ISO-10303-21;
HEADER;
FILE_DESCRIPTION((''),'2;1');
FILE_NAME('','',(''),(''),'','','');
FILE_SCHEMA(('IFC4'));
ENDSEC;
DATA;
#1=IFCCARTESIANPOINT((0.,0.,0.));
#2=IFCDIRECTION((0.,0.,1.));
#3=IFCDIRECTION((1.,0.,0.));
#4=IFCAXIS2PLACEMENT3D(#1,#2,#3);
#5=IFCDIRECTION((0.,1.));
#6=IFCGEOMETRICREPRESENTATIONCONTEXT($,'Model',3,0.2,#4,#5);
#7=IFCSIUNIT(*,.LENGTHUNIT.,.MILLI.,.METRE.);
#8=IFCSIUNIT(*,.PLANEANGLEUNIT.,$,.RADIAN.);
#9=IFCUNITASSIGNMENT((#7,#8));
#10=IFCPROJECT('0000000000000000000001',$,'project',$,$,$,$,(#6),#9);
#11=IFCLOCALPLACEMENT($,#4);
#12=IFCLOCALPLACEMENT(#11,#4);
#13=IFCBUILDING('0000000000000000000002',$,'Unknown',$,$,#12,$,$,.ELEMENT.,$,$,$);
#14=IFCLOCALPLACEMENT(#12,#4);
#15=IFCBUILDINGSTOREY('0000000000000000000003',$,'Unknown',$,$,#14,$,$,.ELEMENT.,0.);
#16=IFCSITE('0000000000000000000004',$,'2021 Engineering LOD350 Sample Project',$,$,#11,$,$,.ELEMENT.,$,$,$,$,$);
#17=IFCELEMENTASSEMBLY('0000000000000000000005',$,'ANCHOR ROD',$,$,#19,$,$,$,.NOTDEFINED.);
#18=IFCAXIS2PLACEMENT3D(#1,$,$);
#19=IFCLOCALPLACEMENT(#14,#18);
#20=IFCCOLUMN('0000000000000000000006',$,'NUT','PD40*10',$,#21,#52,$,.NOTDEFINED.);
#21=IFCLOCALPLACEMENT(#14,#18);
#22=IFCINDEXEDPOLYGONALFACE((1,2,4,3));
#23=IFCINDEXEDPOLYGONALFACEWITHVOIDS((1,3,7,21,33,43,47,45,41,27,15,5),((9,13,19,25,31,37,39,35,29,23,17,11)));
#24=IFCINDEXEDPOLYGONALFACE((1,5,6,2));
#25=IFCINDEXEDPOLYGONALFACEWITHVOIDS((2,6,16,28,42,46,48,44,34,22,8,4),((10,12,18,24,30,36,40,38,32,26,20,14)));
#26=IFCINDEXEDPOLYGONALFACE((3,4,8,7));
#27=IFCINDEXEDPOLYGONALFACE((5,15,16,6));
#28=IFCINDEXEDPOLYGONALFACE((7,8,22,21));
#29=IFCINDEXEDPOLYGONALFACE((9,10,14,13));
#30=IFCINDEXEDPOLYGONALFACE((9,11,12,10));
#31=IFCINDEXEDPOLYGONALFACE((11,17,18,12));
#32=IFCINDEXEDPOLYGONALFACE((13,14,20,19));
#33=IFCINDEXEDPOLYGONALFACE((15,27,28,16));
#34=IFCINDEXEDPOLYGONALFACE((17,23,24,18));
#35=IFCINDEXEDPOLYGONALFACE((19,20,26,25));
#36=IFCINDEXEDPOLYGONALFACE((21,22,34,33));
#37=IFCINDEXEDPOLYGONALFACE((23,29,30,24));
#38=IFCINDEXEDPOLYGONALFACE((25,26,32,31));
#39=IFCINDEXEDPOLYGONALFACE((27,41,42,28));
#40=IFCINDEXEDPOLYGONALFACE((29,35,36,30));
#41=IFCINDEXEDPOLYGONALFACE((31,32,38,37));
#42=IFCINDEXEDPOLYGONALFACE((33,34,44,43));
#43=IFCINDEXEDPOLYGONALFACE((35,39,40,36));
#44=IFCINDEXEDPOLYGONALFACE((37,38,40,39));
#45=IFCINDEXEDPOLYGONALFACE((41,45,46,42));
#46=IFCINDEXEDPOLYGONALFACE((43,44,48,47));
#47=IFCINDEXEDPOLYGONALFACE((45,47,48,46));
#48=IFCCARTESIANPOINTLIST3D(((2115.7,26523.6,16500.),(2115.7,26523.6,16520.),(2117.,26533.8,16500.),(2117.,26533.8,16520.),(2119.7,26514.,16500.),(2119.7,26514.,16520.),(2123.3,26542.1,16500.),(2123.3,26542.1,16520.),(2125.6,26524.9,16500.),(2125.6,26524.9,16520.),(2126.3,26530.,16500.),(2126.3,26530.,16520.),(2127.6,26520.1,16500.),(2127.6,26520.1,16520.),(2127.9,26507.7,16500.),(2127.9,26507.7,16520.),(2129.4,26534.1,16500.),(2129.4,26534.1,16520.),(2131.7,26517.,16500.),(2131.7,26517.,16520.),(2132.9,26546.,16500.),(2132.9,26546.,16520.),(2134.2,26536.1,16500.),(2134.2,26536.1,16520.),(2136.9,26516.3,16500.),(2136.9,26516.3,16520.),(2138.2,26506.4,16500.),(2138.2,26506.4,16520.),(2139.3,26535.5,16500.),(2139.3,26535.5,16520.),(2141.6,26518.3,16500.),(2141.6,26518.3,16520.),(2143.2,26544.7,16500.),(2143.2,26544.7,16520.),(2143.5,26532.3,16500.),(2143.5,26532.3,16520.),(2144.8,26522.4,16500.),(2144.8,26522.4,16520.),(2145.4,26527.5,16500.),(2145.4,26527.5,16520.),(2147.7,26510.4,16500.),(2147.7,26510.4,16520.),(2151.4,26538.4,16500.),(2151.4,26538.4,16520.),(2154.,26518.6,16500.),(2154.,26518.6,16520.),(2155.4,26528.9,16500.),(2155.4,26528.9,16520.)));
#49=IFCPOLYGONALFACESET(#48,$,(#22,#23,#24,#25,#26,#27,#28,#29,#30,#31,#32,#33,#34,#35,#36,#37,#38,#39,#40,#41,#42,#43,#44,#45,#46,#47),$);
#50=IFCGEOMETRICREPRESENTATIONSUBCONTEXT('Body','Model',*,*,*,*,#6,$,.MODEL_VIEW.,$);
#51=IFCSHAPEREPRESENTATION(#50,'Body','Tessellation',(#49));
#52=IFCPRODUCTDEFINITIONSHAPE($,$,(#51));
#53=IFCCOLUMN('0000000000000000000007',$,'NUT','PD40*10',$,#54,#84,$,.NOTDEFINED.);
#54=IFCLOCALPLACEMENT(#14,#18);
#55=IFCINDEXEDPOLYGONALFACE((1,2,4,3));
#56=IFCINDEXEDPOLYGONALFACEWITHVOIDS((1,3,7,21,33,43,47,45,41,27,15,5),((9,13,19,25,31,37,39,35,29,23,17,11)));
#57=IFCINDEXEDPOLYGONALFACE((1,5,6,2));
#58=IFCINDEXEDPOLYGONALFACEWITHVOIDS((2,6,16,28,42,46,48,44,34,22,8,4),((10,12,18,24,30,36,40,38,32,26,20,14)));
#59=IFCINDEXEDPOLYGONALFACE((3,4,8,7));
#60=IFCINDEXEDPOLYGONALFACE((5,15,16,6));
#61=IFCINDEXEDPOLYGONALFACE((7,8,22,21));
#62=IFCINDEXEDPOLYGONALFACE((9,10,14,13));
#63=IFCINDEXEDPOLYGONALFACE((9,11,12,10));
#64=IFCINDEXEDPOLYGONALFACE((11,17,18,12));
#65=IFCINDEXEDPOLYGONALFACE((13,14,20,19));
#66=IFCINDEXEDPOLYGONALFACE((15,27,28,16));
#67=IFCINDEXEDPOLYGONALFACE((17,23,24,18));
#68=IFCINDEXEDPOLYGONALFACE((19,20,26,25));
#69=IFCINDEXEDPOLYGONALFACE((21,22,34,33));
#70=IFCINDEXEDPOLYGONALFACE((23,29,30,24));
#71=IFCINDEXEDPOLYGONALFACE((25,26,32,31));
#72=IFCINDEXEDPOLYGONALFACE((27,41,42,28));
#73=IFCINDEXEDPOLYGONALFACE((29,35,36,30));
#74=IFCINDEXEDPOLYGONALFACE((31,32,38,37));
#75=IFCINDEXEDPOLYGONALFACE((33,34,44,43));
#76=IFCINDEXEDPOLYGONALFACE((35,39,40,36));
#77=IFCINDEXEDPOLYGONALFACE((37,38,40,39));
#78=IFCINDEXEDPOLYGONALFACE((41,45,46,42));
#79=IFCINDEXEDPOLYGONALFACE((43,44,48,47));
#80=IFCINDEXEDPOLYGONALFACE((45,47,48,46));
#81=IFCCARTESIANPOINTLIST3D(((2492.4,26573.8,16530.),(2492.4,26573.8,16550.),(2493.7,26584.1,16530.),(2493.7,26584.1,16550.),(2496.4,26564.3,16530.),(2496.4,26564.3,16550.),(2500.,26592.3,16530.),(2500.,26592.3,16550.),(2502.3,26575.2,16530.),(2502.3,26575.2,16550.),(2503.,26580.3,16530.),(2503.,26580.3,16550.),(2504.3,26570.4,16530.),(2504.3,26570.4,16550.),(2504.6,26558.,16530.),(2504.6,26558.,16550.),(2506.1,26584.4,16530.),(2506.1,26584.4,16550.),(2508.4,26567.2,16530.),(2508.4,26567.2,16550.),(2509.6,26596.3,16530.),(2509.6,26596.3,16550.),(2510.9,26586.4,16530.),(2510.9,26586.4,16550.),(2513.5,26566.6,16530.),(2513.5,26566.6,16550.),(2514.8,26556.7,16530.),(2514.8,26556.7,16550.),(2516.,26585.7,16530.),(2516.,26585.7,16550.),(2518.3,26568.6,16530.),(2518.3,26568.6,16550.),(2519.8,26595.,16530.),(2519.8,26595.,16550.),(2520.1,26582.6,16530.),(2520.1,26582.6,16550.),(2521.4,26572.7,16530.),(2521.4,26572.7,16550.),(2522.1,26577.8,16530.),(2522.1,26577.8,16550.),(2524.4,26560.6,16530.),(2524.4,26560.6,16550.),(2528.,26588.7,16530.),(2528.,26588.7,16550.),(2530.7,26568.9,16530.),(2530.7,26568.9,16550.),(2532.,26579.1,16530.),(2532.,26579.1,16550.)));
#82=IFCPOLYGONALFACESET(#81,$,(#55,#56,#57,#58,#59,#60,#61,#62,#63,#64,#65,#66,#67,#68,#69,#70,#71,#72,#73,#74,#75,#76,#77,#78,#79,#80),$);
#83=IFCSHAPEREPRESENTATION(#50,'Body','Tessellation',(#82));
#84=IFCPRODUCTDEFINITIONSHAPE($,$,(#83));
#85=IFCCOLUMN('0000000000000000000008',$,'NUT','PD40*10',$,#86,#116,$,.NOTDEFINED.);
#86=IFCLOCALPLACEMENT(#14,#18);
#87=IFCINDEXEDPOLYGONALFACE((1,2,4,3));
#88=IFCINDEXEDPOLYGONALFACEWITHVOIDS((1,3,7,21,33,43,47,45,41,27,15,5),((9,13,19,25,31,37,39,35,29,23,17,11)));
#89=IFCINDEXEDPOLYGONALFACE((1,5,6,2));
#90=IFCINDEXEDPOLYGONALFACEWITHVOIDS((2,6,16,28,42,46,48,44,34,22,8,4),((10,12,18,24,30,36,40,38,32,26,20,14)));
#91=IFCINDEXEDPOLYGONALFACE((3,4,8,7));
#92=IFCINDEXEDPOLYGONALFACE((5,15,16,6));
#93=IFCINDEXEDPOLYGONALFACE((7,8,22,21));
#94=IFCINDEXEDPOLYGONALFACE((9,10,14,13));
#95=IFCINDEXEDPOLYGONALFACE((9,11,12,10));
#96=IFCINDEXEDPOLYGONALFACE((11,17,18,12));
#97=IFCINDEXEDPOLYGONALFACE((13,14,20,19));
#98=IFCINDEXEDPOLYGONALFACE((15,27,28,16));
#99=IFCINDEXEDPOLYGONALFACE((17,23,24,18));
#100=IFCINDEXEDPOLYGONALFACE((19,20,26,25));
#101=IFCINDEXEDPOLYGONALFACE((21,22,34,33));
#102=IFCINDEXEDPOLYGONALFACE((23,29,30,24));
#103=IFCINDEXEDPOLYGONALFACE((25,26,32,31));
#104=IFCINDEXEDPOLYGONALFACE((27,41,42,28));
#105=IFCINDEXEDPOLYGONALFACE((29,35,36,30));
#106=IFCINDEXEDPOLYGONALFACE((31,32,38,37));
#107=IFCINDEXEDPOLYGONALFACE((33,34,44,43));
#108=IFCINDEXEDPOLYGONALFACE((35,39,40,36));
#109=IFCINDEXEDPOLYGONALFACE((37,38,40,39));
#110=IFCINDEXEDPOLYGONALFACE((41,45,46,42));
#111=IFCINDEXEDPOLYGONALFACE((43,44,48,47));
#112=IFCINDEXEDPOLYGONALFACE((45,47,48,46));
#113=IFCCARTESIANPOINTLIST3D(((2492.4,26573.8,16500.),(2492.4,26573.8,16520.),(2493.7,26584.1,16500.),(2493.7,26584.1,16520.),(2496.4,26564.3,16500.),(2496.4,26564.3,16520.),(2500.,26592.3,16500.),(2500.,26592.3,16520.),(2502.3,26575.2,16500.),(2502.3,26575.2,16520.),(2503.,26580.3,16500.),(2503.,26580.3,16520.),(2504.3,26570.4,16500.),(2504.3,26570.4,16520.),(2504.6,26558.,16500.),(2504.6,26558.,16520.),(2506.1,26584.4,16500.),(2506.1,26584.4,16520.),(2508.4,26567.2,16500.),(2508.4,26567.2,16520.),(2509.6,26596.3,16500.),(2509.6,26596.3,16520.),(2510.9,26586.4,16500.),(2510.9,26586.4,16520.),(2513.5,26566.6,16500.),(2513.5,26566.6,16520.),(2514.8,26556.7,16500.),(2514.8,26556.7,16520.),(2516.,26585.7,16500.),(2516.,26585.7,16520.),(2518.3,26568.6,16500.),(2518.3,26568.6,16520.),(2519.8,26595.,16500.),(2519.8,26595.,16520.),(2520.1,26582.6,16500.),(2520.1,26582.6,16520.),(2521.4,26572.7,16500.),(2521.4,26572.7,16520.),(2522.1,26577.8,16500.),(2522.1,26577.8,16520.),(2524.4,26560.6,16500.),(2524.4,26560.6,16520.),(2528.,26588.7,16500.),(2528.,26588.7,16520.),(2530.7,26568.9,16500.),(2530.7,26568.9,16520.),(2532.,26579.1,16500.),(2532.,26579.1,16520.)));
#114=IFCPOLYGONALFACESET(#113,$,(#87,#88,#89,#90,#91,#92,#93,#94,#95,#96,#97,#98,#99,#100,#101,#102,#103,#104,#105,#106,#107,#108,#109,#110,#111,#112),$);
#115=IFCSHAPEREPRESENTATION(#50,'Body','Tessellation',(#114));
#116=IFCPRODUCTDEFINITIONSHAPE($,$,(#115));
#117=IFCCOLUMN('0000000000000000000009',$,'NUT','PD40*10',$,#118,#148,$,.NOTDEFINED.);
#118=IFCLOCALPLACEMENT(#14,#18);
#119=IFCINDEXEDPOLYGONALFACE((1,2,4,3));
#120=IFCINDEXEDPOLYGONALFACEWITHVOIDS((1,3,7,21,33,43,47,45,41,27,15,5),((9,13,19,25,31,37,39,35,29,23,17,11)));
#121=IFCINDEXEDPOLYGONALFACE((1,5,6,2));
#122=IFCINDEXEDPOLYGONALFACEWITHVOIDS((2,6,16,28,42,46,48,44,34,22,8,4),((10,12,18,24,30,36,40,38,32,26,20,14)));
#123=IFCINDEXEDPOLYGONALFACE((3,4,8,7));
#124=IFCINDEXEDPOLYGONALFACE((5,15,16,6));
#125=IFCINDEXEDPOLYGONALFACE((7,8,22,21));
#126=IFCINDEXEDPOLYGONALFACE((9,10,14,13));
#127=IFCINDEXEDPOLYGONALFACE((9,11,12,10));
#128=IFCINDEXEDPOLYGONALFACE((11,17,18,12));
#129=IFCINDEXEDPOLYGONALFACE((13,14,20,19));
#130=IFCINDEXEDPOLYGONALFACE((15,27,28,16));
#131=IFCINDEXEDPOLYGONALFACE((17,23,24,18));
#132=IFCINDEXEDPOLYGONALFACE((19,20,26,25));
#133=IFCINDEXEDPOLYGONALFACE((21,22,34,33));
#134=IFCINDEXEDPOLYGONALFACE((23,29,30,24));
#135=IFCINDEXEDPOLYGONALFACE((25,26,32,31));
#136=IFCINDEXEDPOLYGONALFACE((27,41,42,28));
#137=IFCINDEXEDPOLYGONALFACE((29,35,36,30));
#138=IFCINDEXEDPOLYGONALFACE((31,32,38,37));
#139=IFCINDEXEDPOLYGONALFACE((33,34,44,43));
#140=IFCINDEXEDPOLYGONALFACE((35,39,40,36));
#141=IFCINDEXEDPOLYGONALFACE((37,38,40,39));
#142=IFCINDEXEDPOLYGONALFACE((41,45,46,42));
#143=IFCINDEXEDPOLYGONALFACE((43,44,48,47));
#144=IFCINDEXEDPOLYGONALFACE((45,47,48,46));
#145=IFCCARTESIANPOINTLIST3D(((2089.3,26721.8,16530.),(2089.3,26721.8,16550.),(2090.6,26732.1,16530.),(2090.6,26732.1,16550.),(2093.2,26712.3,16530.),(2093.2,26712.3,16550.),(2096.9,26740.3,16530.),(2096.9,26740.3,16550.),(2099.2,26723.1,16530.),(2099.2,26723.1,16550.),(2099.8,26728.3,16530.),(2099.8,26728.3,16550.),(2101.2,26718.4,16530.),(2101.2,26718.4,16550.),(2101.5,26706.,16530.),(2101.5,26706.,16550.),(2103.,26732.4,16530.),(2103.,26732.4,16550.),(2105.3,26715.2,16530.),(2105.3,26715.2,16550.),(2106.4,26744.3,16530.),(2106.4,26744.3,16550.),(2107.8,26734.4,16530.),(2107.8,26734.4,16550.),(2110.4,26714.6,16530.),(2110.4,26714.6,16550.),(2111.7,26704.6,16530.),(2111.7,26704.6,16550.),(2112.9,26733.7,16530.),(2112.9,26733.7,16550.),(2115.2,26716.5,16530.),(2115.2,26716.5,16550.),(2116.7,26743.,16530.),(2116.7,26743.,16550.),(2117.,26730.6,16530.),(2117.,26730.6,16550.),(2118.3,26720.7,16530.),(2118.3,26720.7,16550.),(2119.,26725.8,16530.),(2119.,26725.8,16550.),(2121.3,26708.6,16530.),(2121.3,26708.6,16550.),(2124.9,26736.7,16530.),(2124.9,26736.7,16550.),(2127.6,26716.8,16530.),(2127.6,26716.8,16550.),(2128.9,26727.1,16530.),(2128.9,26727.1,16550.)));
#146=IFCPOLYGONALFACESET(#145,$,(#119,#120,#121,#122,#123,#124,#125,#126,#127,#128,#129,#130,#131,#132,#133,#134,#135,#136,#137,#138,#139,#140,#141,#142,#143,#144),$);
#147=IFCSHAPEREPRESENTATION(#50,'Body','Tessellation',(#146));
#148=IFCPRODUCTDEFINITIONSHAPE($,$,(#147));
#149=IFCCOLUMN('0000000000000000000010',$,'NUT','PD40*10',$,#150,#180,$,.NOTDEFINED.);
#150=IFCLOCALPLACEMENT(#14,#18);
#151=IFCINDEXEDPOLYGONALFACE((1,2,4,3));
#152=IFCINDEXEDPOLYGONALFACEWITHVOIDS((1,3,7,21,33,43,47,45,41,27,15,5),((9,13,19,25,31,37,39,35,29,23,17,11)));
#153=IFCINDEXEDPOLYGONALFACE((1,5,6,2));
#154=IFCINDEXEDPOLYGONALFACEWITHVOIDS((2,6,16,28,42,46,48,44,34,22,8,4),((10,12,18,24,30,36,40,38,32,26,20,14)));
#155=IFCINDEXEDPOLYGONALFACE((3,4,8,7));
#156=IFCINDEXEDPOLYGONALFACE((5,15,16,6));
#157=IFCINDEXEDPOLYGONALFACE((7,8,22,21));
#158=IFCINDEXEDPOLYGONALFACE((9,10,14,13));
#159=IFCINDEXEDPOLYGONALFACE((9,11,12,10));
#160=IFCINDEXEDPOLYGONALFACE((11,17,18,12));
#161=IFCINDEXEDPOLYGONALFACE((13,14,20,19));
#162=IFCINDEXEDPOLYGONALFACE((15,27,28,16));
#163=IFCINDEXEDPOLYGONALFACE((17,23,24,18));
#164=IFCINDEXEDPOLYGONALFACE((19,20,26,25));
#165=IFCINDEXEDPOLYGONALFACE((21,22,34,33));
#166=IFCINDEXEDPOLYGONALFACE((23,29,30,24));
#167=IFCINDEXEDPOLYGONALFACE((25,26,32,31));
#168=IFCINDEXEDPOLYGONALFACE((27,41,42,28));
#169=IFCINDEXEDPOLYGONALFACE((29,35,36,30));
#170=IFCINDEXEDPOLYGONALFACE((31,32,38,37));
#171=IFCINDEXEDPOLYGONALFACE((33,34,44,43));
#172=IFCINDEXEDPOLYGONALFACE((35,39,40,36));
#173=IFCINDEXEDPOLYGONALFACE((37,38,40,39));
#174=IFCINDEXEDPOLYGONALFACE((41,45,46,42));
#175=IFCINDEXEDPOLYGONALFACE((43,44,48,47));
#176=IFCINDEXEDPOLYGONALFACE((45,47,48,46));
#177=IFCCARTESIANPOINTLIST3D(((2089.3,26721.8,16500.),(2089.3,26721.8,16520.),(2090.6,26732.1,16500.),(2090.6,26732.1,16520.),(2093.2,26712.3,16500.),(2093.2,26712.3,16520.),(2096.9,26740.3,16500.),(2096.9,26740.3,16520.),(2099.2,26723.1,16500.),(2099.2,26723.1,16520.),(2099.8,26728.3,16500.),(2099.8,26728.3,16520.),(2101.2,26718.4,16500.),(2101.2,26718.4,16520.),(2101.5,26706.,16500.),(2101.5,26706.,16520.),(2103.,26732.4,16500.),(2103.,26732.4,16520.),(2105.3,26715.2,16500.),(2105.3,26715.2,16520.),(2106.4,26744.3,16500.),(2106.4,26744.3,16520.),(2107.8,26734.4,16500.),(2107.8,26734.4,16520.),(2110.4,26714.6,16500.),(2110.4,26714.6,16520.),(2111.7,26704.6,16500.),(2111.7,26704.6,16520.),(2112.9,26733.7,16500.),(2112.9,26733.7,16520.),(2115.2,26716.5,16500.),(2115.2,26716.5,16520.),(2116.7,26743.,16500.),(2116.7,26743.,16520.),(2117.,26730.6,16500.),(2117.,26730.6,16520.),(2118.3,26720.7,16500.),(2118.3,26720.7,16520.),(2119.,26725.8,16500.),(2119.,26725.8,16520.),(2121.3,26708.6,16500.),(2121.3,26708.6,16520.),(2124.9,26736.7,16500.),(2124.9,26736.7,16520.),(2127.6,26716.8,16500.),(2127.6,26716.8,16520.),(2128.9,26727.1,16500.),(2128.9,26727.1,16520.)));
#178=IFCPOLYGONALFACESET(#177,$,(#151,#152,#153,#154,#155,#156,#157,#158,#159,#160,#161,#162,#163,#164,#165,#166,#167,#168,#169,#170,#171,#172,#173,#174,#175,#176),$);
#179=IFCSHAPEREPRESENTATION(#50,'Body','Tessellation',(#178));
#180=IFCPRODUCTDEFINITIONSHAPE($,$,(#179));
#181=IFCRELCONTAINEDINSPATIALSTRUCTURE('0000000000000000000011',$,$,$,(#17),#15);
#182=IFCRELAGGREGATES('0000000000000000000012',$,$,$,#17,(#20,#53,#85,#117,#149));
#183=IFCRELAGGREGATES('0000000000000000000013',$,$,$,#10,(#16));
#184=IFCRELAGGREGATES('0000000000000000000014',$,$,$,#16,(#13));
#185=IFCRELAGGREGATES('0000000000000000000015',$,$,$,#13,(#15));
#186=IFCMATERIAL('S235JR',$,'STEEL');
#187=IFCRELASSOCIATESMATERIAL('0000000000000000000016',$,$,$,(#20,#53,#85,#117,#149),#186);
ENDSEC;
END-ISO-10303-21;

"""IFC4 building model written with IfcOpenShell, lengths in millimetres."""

from ifc_helpers import new_model, si_unit, direction, frame, origin_with_axes, place, context, subcontext, project, spatial, line, indexed_curve, outline, extrude, material, element, aggregate, save


model = new_model("IFC4")

# Units and contexts
model_context = context("Model", 3, precision=0.2, world=origin_with_axes(), true_north=direction((0.0, 1.0)))
body_context = subcontext(model_context, "Body", "Model", "MODEL_VIEW")
ifc_project = project(units=[si_unit("LENGTHUNIT", "METRE", prefix="MILLI"), si_unit("PLANEANGLEUNIT", "RADIAN")], contexts=[model_context])

# Site, building, storey
site_placement = place(None, origin_with_axes())
site = spatial("IfcSite", under=ifc_project, at=site_placement, Name="2021 Engineering LOD350 Sample Project", CompositionType="ELEMENT")
building_placement = place(site_placement, origin_with_axes())
building = spatial("IfcBuilding", under=site, at=building_placement, Name="Unknown", CompositionType="ELEMENT")
storey_placement = place(building_placement, origin_with_axes())
storey = spatial("IfcBuildingStorey", under=building, at=storey_placement, Name="Unknown", CompositionType="ELEMENT", Elevation=0.0)

# Element assembly, columns
assembly_1_placement = place(storey_placement, frame((2485.7, 26774.7, 16730.0), z_axis=(0.991216, 0.132256, 0.0), x_axis=(0.0, 0.0, -1.0)))
assembly_1 = element("IfcElementAssembly", 1, at=assembly_1_placement, inside=storey, Name="ANCHOR ROD", PredefinedType="NOTDEFINED")
ifc_material_1 = material(Name="S235JR", Category="STEEL")
column_1_placement = place(assembly_1_placement, frame((210.0, -200.0, -380.0), z_axis=(0.0, 0.0, -1.0), x_axis=(1.0, 0.0, 0.0)))
column_1 = element("IfcColumn", 2, at=column_1_placement, material=ifc_material_1, Name="NUT", Description="PD40*10", PredefinedType="NOTDEFINED", context=body_context, shape_type="SolidModel", body=[
    extrude(outline(indexed_curve([(20.0, 0.0), (17.3, 10.0), (10.0, 17.3), (0.0, 20.0), (-10.0, 17.3), (-17.3, 10.0), (-20.0, 0.0), (-17.3, -10.0), (-10.0, -17.3), (0.0, -20.0), (10.0, -17.3), (17.3, -10.0)], segments=[line(1, 2, 3, 4, 5, 6, 7, 8, 9, 10, 11, 12, 1)]), holes=[indexed_curve([(10.0, 0.0), (8.7, -5.0), (5.0, -8.7), (0.0, -10.0), (-5.0, -8.7), (-8.7, -5.0), (-10.0, 0.0), (-8.7, 5.0), (-5.0, 8.7), (0.0, 10.0), (5.0, 8.7), (8.7, 5.0)], segments=[line(1, 2, 3, 4, 5, 6, 7, 8, 9, 10, 11, 12, 1)])]), frame((0.0, 0.0, 0.0), z_axis=(-1.0, 0.0, 0.0), x_axis=(0.0, 0.0, 1.0)), (0.0, 0.0, -1.0), 20.0),
])
column_2_placement = place(assembly_1_placement, frame((180.0, -200.0, 0.0), z_axis=(0.0, 0.0, 1.0), x_axis=(1.0, 0.0, 0.0)))
column_2 = element("IfcColumn", 3, at=column_2_placement, material=ifc_material_1, Name="NUT", Description="PD40*10", PredefinedType="NOTDEFINED", context=body_context, shape_type="SolidModel", body=[
    extrude(outline(indexed_curve([(20.0, 0.0), (17.3, 10.0), (10.0, 17.3), (0.0, 20.0), (-10.0, 17.3), (-17.3, 10.0), (-20.0, 0.0), (-17.3, -10.0), (-10.0, -17.3), (0.0, -20.0), (10.0, -17.3), (17.3, -10.0)], segments=[line(1, 2, 3, 4, 5, 6, 7, 8, 9, 10, 11, 12, 1)]), holes=[indexed_curve([(10.0, 0.0), (8.7, -5.0), (5.0, -8.7), (0.0, -10.0), (-5.0, -8.7), (-8.7, -5.0), (-10.0, 0.0), (-8.7, 5.0), (-5.0, 8.7), (0.0, 10.0), (5.0, 8.7), (8.7, 5.0)], segments=[line(1, 2, 3, 4, 5, 6, 7, 8, 9, 10, 11, 12, 1)])]), frame((0.0, 0.0, 0.0), z_axis=(-1.0, 0.0, 0.0), x_axis=(0.0, 0.0, 1.0)), (0.0, 0.0, -1.0), 20.0),
])
column_3_placement = place(assembly_1_placement, frame((210.0, -200.0, 0.0), z_axis=(0.0, 0.0, 1.0), x_axis=(1.0, 0.0, 0.0)))
column_3 = element("IfcColumn", 4, at=column_3_placement, material=ifc_material_1, Name="NUT", Description="PD40*10", PredefinedType="NOTDEFINED", context=body_context, shape_type="SolidModel", body=[
    extrude(outline(indexed_curve([(20.0, 0.0), (17.3, 10.0), (10.0, 17.3), (0.0, 20.0), (-10.0, 17.3), (-17.3, 10.0), (-20.0, 0.0), (-17.3, -10.0), (-10.0, -17.3), (0.0, -20.0), (10.0, -17.3), (17.3, -10.0)], segments=[line(1, 2, 3, 4, 5, 6, 7, 8, 9, 10, 11, 12, 1)]), holes=[indexed_curve([(10.0, 0.0), (8.7, -5.0), (5.0, -8.7), (0.0, -10.0), (-5.0, -8.7), (-8.7, -5.0), (-10.0, 0.0), (-8.7, 5.0), (-5.0, 8.7), (0.0, 10.0), (5.0, 8.7), (8.7, 5.0)], segments=[line(1, 2, 3, 4, 5, 6, 7, 8, 9, 10, 11, 12, 1)])]), frame((0.0, 0.0, 0.0), z_axis=(-1.0, 0.0, 0.0), x_axis=(0.0, 0.0, 1.0)), (0.0, 0.0, -1.0), 20.0),
])
column_4_placement = place(assembly_1_placement, frame((180.0, 0.0, -380.0), z_axis=(0.0, 0.0, -1.0), x_axis=(1.0, 0.0, 0.0)))
column_4 = element("IfcColumn", 5, at=column_4_placement, material=ifc_material_1, Name="NUT", Description="PD40*10", PredefinedType="NOTDEFINED", context=body_context, shape_type="SolidModel", body=[
    extrude(outline(indexed_curve([(20.0, 0.0), (17.3, 10.0), (10.0, 17.3), (0.0, 20.0), (-10.0, 17.3), (-17.3, 10.0), (-20.0, 0.0), (-17.3, -10.0), (-10.0, -17.3), (0.0, -20.0), (10.0, -17.3), (17.3, -10.0)], segments=[line(1, 2, 3, 4, 5, 6, 7, 8, 9, 10, 11, 12, 1)]), holes=[indexed_curve([(10.0, 0.0), (8.7, -5.0), (5.0, -8.7), (0.0, -10.0), (-5.0, -8.7), (-8.7, -5.0), (-10.0, 0.0), (-8.7, 5.0), (-5.0, 8.7), (0.0, 10.0), (5.0, 8.7), (8.7, 5.0)], segments=[line(1, 2, 3, 4, 5, 6, 7, 8, 9, 10, 11, 12, 1)])]), frame((0.0, 0.0, 0.0), z_axis=(-1.0, 0.0, 0.0), x_axis=(0.0, 0.0, 1.0)), (0.0, 0.0, -1.0), 20.0),
])
column_5_placement = place(assembly_1_placement, frame((210.0, 0.0, -380.0), z_axis=(0.0, 0.0, -1.0), x_axis=(1.0, 0.0, 0.0)))
column_5 = element("IfcColumn", 6, at=column_5_placement, material=ifc_material_1, Name="NUT", Description="PD40*10", PredefinedType="NOTDEFINED", context=body_context, shape_type="SolidModel", body=[
    extrude(outline(indexed_curve([(20.0, 0.0), (17.3, 10.0), (10.0, 17.3), (0.0, 20.0), (-10.0, 17.3), (-17.3, 10.0), (-20.0, 0.0), (-17.3, -10.0), (-10.0, -17.3), (0.0, -20.0), (10.0, -17.3), (17.3, -10.0)], segments=[line(1, 2, 3, 4, 5, 6, 7, 8, 9, 10, 11, 12, 1)]), holes=[indexed_curve([(10.0, 0.0), (8.7, -5.0), (5.0, -8.7), (0.0, -10.0), (-5.0, -8.7), (-8.7, -5.0), (-10.0, 0.0), (-8.7, 5.0), (-5.0, 8.7), (0.0, 10.0), (5.0, 8.7), (8.7, 5.0)], segments=[line(1, 2, 3, 4, 5, 6, 7, 8, 9, 10, 11, 12, 1)])]), frame((0.0, 0.0, 0.0), z_axis=(-1.0, 0.0, 0.0), x_axis=(0.0, 0.0, 1.0)), (0.0, 0.0, -1.0), 20.0),
])

aggregate(assembly_1, [column_1, column_2, column_3, column_4, column_5])

save(model, "model.ifc")
